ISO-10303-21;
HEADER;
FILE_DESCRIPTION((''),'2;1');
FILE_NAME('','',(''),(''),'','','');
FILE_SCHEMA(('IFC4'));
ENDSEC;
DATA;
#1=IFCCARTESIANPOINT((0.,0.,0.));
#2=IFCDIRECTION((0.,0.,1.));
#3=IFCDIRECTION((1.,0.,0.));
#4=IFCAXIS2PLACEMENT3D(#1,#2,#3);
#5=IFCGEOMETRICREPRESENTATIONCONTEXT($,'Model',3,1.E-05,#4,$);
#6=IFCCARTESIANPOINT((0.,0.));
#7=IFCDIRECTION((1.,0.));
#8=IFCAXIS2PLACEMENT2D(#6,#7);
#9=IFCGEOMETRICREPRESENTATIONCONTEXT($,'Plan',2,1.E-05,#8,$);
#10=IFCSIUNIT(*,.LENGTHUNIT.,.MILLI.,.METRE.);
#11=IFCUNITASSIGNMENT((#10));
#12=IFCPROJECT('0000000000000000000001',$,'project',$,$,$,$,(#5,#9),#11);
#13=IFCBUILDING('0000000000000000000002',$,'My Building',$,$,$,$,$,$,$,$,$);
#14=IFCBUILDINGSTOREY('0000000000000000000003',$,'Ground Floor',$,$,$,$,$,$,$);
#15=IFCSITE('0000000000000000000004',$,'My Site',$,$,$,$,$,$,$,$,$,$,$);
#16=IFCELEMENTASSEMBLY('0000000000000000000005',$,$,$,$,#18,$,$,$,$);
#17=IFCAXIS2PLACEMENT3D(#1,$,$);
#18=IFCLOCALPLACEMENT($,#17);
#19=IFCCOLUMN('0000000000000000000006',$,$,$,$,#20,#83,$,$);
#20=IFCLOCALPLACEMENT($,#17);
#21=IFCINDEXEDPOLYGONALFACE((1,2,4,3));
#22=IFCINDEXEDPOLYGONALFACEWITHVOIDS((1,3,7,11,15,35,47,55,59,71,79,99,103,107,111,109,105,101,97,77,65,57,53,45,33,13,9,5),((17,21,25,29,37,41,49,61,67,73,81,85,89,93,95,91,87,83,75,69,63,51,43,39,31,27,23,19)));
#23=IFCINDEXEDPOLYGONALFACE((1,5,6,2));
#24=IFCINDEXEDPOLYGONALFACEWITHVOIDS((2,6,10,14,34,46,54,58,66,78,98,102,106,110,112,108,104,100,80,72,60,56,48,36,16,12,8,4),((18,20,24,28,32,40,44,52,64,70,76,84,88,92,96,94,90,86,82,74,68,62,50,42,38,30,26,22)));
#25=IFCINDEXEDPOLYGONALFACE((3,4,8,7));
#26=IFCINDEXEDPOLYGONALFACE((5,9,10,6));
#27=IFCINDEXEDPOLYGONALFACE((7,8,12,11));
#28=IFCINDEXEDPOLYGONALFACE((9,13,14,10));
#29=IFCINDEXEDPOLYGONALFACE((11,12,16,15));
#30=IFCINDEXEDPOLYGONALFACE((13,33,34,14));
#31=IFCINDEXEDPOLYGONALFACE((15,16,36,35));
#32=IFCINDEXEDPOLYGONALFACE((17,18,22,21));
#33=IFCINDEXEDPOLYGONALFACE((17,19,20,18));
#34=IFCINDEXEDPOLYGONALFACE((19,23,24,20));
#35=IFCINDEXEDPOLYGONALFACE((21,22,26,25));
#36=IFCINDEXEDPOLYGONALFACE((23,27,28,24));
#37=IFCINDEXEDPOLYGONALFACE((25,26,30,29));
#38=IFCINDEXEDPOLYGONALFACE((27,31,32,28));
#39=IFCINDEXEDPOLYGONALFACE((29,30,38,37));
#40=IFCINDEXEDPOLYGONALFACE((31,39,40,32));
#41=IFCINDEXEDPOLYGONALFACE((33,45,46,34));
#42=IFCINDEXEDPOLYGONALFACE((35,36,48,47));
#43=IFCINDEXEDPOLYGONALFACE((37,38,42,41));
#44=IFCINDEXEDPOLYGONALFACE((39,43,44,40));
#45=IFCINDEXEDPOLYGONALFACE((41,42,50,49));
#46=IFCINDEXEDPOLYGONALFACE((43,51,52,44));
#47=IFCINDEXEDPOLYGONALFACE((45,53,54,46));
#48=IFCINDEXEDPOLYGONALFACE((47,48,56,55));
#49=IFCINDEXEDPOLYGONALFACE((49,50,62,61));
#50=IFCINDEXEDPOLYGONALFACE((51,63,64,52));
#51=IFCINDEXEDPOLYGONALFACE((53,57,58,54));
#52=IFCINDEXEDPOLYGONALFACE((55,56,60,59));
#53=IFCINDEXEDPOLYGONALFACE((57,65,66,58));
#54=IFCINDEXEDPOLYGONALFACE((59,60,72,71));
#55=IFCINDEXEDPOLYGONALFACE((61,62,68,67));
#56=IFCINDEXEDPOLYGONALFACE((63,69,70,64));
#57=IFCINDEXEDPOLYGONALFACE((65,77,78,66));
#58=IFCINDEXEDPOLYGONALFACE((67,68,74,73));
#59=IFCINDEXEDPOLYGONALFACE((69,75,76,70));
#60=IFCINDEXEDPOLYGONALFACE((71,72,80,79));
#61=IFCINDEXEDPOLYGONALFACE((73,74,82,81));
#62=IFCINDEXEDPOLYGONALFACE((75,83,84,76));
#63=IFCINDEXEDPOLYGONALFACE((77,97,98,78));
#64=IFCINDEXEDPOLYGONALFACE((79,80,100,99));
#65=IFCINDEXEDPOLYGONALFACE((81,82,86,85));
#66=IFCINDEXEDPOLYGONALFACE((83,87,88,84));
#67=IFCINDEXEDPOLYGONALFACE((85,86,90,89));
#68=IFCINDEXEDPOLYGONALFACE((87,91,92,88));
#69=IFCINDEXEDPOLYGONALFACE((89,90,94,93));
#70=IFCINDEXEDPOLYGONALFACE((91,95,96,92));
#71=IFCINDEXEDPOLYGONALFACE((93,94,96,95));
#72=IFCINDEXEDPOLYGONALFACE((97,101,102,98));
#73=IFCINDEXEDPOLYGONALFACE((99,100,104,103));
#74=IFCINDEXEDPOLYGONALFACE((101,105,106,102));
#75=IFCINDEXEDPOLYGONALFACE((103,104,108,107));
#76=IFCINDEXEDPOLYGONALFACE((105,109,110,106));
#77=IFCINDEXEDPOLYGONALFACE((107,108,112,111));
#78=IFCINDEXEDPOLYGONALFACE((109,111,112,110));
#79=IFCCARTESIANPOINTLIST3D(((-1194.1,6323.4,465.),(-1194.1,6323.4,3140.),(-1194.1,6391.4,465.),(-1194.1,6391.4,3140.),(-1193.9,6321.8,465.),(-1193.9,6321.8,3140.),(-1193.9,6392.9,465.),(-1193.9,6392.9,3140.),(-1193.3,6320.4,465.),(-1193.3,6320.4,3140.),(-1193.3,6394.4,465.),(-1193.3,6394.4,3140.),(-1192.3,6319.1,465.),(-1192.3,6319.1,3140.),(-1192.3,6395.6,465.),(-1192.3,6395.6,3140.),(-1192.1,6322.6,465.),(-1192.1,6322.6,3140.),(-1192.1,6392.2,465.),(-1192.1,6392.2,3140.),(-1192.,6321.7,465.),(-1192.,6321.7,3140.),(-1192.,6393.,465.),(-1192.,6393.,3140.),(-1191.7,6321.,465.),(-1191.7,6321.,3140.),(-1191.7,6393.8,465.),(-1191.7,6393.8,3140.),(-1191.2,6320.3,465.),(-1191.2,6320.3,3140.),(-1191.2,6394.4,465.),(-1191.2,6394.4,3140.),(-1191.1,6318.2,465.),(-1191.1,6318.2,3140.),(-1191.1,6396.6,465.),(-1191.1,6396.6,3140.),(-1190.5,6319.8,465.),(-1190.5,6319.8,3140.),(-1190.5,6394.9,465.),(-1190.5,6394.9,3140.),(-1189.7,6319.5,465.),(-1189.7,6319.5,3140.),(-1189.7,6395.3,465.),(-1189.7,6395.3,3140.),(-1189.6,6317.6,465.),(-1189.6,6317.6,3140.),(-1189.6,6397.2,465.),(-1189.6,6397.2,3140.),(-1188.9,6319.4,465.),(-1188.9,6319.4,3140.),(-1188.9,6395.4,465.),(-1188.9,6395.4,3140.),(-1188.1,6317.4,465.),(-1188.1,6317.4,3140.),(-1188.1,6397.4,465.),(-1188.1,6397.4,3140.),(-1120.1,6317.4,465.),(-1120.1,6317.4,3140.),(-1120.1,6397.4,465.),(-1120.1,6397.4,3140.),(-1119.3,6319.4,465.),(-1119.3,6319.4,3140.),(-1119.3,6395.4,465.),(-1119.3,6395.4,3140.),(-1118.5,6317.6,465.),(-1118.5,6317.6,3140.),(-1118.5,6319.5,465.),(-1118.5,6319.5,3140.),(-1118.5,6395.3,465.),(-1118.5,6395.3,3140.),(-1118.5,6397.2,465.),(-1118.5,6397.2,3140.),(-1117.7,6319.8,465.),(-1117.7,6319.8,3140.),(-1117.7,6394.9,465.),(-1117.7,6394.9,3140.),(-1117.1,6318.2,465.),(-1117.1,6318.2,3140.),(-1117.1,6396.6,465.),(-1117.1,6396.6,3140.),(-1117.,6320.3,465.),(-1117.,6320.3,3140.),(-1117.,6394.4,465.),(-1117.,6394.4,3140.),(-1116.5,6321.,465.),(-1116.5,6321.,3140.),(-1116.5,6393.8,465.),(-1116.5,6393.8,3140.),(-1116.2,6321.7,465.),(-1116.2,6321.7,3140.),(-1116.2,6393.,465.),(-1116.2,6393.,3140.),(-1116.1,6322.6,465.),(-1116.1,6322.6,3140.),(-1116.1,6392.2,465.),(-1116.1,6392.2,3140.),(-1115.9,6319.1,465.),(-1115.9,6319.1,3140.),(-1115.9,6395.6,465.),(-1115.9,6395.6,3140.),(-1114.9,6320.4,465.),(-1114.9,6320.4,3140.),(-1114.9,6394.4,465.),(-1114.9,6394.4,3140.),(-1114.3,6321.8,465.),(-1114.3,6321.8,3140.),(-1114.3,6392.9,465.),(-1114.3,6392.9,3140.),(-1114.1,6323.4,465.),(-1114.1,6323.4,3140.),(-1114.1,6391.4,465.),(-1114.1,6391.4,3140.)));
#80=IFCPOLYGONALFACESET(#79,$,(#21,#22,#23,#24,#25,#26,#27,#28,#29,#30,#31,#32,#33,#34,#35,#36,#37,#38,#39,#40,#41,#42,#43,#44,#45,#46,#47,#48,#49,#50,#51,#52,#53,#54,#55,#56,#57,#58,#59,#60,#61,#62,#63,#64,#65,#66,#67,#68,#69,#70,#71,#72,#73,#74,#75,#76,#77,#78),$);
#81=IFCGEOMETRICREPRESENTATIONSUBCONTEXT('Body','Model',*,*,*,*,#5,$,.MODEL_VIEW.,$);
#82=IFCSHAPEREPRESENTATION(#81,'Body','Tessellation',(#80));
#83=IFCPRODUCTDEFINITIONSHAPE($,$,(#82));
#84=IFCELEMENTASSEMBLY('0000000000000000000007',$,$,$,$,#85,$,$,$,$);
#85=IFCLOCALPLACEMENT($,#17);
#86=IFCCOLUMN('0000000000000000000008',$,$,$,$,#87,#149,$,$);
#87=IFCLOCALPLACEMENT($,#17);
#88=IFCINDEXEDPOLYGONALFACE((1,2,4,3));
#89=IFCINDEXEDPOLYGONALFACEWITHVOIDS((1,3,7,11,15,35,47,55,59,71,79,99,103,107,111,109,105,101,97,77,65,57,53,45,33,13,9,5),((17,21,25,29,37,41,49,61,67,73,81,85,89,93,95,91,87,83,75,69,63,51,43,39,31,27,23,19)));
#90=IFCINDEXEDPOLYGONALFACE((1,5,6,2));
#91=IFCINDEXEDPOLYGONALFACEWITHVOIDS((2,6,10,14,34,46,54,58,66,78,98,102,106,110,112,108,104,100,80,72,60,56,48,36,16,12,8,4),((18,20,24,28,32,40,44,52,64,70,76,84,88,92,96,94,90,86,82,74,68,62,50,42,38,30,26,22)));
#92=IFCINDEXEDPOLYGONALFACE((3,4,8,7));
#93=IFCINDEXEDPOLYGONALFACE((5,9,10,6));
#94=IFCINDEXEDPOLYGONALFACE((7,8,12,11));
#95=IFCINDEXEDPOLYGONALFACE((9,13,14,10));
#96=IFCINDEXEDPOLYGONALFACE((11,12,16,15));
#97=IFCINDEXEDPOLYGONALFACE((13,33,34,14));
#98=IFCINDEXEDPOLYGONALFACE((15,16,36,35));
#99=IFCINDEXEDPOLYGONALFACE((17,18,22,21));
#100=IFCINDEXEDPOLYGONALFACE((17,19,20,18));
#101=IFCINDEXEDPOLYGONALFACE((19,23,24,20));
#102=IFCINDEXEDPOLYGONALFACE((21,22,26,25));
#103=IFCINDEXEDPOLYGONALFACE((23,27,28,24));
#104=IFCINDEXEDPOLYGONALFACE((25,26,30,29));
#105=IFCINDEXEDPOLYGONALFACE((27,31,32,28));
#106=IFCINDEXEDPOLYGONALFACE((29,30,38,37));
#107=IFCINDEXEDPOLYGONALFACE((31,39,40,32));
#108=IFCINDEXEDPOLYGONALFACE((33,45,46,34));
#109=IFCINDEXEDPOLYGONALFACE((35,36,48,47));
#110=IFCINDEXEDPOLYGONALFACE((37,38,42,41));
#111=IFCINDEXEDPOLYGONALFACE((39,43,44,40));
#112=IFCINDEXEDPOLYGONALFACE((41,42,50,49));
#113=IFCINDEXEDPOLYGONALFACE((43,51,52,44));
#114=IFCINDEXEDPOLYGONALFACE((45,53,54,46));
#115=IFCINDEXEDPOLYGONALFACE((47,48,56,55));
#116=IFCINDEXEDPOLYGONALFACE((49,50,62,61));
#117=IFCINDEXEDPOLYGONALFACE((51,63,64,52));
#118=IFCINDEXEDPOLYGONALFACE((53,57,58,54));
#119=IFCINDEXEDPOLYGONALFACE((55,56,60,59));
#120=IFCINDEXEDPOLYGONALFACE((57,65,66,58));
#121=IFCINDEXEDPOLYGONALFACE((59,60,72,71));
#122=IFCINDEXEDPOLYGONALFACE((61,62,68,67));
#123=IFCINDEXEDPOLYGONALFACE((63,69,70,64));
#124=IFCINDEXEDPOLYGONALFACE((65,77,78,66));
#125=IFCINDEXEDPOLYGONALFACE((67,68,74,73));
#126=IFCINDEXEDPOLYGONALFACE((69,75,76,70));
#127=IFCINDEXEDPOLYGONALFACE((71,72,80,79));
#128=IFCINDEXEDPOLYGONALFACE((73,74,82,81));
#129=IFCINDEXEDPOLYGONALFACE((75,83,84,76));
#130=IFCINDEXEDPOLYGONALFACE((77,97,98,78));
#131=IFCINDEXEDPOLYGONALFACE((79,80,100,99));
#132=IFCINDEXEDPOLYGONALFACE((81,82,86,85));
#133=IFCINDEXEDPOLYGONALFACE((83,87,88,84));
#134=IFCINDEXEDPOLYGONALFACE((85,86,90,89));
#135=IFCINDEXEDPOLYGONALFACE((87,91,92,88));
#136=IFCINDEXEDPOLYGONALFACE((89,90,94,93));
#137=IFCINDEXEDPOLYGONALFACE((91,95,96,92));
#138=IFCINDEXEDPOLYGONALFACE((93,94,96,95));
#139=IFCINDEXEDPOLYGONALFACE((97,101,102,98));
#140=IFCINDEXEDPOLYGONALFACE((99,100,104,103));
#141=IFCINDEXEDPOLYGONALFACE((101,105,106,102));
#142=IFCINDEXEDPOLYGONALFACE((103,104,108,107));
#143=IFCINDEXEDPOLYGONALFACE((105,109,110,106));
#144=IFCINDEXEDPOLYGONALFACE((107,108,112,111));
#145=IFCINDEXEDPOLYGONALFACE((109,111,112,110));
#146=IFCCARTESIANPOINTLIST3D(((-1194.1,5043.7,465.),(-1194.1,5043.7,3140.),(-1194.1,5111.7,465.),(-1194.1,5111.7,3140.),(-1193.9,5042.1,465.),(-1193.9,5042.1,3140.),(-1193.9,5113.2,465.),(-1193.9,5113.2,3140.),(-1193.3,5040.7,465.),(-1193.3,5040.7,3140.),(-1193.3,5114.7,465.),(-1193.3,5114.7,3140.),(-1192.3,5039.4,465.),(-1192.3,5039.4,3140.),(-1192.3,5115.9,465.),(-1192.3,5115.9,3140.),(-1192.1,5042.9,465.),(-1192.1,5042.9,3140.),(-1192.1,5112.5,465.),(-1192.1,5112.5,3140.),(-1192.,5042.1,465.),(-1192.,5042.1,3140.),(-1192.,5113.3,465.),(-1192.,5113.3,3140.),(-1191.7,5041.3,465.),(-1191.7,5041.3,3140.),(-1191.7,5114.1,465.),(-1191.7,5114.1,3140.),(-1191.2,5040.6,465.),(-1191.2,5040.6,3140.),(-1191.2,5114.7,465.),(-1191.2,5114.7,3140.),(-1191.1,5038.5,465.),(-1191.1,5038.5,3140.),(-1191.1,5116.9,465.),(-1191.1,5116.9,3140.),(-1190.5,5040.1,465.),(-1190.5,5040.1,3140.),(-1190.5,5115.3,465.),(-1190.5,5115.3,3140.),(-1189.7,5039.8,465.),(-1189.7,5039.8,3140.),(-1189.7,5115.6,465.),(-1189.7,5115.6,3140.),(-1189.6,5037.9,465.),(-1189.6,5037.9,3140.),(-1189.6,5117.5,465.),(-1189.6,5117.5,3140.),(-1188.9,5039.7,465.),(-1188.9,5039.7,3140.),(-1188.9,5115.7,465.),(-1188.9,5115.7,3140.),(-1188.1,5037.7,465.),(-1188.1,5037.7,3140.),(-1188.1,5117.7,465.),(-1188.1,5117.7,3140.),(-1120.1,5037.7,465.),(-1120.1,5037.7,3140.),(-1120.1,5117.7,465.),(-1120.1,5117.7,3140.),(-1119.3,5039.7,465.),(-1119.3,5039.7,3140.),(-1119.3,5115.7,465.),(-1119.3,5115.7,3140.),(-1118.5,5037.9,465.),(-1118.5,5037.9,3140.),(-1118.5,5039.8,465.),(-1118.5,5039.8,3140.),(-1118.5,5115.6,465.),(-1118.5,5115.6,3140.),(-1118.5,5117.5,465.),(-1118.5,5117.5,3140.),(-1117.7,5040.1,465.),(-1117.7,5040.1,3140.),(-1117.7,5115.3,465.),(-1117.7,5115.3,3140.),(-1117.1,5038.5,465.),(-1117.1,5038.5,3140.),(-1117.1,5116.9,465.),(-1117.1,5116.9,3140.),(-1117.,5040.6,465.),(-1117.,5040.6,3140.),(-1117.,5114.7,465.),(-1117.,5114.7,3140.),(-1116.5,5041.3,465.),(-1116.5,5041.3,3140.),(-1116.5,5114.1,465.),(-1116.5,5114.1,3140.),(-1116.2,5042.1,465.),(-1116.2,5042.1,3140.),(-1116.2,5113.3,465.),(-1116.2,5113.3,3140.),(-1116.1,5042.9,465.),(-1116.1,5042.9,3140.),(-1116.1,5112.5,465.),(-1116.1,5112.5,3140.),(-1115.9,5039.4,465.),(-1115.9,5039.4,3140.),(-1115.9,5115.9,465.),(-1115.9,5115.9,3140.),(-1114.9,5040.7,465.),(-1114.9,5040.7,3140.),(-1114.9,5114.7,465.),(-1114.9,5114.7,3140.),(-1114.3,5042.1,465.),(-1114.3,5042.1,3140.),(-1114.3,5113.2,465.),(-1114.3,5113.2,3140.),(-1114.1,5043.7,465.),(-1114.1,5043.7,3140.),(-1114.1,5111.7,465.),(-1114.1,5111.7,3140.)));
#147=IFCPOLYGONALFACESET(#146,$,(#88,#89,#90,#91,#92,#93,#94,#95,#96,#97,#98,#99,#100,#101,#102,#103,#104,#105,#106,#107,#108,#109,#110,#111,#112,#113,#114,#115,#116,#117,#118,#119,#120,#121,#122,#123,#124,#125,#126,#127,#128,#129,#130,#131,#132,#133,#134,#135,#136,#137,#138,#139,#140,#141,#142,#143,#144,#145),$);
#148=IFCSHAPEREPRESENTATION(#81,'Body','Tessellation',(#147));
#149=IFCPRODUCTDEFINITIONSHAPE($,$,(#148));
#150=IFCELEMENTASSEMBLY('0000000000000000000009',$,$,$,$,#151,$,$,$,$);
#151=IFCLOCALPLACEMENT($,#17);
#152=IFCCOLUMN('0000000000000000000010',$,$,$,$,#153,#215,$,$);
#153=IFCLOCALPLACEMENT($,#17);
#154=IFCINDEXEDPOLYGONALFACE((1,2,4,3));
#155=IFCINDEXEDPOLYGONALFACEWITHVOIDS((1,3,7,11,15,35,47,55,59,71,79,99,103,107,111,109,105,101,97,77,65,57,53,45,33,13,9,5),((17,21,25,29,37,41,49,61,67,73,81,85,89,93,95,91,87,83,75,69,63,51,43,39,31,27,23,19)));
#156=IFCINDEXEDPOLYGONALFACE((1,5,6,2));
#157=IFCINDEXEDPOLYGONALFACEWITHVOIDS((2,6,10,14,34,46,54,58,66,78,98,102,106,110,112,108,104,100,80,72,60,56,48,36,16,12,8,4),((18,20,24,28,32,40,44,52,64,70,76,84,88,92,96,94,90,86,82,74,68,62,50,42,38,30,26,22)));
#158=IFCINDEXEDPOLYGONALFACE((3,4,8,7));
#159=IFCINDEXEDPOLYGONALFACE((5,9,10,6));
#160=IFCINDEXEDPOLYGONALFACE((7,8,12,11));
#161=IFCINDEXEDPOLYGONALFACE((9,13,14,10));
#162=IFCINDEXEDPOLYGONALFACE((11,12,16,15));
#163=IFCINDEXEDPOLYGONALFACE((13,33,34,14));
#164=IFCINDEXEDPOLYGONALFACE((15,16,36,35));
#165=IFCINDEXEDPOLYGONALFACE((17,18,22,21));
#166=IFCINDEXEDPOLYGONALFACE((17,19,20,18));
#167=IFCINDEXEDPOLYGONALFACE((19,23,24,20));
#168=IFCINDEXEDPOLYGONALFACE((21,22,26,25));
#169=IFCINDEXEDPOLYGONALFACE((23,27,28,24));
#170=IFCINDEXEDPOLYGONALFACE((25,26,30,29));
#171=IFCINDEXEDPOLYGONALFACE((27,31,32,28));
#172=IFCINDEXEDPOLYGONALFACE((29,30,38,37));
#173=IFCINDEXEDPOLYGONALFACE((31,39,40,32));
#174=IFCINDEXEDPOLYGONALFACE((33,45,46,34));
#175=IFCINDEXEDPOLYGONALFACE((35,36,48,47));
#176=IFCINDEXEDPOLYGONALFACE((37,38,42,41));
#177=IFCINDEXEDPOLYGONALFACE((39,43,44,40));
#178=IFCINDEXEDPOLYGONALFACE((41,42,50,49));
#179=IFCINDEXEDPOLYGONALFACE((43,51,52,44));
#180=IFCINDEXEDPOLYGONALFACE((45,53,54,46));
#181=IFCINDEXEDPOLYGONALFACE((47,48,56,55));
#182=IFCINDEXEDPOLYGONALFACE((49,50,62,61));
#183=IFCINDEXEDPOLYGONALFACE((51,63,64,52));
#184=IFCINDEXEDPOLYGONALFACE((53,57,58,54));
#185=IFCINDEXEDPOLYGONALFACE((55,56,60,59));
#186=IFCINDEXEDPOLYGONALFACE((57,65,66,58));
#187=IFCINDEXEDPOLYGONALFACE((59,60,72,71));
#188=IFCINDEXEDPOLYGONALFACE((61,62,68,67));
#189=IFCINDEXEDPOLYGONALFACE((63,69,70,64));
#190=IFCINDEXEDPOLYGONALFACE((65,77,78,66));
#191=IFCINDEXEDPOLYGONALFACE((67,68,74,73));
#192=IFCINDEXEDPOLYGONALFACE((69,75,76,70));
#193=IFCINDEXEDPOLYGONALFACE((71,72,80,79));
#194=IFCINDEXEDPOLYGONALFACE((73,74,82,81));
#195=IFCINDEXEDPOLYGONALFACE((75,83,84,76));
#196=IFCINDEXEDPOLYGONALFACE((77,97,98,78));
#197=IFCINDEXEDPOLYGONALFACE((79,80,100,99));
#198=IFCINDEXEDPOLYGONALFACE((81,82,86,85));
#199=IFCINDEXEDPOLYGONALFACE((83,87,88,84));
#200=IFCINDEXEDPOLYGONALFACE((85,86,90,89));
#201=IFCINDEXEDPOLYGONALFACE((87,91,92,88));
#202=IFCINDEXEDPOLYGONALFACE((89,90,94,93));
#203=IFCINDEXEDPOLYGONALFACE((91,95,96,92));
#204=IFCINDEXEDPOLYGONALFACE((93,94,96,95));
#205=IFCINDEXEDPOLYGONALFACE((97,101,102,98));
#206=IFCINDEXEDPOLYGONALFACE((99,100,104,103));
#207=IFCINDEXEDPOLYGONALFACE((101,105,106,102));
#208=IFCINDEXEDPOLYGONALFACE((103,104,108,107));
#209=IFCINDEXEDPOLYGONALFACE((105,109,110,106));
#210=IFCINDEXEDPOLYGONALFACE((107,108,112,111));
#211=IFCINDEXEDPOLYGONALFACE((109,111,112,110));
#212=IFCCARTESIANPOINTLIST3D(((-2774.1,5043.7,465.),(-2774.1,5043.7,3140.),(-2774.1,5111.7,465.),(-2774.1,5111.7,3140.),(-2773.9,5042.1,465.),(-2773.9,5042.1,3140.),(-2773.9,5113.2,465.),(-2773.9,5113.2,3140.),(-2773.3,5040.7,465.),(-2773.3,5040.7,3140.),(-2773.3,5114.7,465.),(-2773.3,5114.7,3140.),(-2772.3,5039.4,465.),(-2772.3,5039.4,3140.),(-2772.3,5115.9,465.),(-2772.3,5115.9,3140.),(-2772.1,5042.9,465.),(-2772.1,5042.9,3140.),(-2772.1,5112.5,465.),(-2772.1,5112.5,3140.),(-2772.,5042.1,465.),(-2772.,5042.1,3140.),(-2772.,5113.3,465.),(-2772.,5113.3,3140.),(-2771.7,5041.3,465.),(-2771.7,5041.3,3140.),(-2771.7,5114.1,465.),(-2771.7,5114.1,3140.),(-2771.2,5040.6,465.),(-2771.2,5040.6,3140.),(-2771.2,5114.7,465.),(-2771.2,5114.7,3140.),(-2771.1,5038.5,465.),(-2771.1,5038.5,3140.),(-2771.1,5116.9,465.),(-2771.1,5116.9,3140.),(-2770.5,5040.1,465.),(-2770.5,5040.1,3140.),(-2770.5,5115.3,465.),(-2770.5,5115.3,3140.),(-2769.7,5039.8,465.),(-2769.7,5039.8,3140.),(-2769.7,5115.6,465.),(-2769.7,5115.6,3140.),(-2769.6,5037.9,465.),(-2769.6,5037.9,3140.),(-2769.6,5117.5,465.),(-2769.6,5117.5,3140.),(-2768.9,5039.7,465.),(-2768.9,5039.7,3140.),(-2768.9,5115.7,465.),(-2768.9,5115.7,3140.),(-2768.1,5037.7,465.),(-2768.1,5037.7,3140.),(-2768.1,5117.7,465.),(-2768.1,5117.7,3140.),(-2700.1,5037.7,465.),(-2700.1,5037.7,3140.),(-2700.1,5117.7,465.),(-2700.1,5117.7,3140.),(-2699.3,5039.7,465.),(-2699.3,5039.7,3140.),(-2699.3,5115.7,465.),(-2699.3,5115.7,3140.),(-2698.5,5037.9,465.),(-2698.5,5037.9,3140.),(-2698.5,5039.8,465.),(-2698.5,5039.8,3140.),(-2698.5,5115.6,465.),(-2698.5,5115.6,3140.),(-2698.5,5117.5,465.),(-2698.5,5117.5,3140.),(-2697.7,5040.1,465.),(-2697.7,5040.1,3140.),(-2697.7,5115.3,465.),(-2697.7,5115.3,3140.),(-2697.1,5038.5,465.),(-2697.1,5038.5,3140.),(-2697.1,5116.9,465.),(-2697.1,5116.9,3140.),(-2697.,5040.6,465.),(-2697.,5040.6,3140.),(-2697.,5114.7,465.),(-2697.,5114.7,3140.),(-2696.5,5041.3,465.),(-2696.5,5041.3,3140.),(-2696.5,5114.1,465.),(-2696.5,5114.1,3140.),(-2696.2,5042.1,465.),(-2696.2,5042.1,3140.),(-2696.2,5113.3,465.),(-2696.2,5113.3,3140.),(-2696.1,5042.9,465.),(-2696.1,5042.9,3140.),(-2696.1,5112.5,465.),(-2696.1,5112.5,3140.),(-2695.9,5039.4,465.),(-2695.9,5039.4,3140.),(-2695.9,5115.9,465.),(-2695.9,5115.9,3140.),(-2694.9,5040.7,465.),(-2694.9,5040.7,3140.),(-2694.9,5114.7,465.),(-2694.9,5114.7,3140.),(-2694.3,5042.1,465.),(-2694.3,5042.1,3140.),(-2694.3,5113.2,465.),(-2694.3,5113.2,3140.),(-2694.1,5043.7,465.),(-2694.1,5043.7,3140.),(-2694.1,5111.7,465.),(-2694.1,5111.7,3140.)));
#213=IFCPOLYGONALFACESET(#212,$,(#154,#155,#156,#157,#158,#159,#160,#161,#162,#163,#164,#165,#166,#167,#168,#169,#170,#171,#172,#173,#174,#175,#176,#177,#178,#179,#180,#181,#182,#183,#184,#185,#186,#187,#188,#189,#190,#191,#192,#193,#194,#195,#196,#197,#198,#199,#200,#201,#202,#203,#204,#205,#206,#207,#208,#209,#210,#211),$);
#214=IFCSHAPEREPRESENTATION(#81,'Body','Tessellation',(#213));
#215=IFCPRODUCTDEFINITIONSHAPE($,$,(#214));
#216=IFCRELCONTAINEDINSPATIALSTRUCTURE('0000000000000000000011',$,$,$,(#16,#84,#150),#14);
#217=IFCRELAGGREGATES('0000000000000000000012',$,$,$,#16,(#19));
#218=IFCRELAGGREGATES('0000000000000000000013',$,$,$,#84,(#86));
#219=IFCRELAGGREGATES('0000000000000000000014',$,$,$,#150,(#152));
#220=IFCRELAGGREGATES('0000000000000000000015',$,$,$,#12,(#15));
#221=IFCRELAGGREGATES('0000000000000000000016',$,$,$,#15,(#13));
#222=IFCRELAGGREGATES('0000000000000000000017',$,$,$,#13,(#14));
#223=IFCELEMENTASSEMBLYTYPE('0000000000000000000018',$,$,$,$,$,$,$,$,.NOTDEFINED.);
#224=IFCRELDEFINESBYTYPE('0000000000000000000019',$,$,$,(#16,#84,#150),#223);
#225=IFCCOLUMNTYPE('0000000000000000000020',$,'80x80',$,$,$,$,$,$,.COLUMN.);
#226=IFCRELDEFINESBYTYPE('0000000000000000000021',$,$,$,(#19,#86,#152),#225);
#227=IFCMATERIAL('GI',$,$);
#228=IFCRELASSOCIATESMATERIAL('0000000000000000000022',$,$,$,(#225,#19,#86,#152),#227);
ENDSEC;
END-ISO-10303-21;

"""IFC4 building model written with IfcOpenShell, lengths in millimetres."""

from ifc_helpers import new_model, si_unit, frame, origin_with_axes, origin_2d_with_axis, place, context, subcontext, project, spatial, hollow_rectangle, extrude, material, material_profile, profile_set, profile_usage, type_object, element, aggregate, save


model = new_model("IFC4")

# Units and contexts
model_context = context("Model", 3, precision=1e-05, world=origin_with_axes())
plan_context = context("Plan", 2, precision=1e-05, world=origin_2d_with_axis())
body_context = subcontext(model_context, "Body", "Model", "MODEL_VIEW")
ifc_project = project(units=[si_unit("LENGTHUNIT", "METRE", prefix="MILLI")], contexts=[model_context, plan_context])

# Site, building, storey
site = spatial("IfcSite", under=ifc_project, Name="My Site")
building = spatial("IfcBuilding", under=site, Name="My Building")
storey = spatial("IfcBuildingStorey", under=building, Name="Ground Floor")

# Element assemblies, columns
element_assembly_type_1 = type_object("IfcElementAssemblyType", PredefinedType="NOTDEFINED")
assembly_1_placement = place(None, frame((-1154.1, 6357.4, 465.0), z_axis=(0.0, 0.0, 1.0), x_axis=(1.0, 0.0, 0.0)))
assembly_1 = element("IfcElementAssembly", 1, at=assembly_1_placement, inside=storey, type_object=element_assembly_type_1)
ifc_material = material(Name="GI")
ifc_material_profile_1 = material_profile(ifc_material, hollow_rectangle(XDim=80.0, YDim=80.0, WallThickness=2.0, InnerFilletRadius=3.2, OuterFilletRadius=6.0))
ifc_profile_set_1 = profile_set([ifc_material_profile_1], Name="80x80 GI Rectangular Hollow")
ifc_profile_usage_1 = profile_usage(ifc_profile_set_1)
column_type = type_object("IfcColumnType", Name="80x80", PredefinedType="COLUMN", material=ifc_profile_set_1)
column_1_placement = place(assembly_1_placement, origin_with_axes())
column_1 = element("IfcColumn", 2, at=column_1_placement, type_object=column_type, material=ifc_profile_usage_1, context=body_context, shape_type="SweptSolid", body=[
    extrude(hollow_rectangle(XDim=80.0, YDim=80.0, WallThickness=2.0, InnerFilletRadius=3.2, OuterFilletRadius=6.0), origin_with_axes(), (0.0, 0.0, 1.0), 2675.0),
])
aggregate(assembly_1, [column_1])
assembly_2_placement = place(None, frame((-1154.1, 5077.7, 465.0), z_axis=(0.0, 0.0, 1.0), x_axis=(1.0, 0.0, 0.0)))
assembly_2 = element("IfcElementAssembly", 3, at=assembly_2_placement, inside=storey, type_object=element_assembly_type_1)
ifc_profile_usage_2 = profile_usage(ifc_profile_set_1)
column_2_placement = place(assembly_2_placement, origin_with_axes())
column_2 = element("IfcColumn", 4, at=column_2_placement, type_object=column_type, material=ifc_profile_usage_2, context=body_context, shape_type="SweptSolid", body=[
    extrude(hollow_rectangle(XDim=80.0, YDim=80.0, WallThickness=2.0, InnerFilletRadius=3.2, OuterFilletRadius=6.0), origin_with_axes(), (0.0, 0.0, 1.0), 2675.0),
])
aggregate(assembly_2, [column_2])
assembly_3_placement = place(None, frame((-2734.1, 5077.7, 465.0), z_axis=(0.0, 0.0, 1.0), x_axis=(1.0, 0.0, 0.0)))
assembly_3 = element("IfcElementAssembly", 5, at=assembly_3_placement, inside=storey, type_object=element_assembly_type_1)
ifc_profile_usage_3 = profile_usage(ifc_profile_set_1)
column_3_placement = place(assembly_3_placement, origin_with_axes())
column_3 = element("IfcColumn", 6, at=column_3_placement, type_object=column_type, material=ifc_profile_usage_3, context=body_context, shape_type="SweptSolid", body=[
    extrude(hollow_rectangle(XDim=80.0, YDim=80.0, WallThickness=2.0, InnerFilletRadius=3.2, OuterFilletRadius=6.0), origin_with_axes(), (0.0, 0.0, 1.0), 2675.0),
])
aggregate(assembly_3, [column_3])

save(model, "model.ifc")
